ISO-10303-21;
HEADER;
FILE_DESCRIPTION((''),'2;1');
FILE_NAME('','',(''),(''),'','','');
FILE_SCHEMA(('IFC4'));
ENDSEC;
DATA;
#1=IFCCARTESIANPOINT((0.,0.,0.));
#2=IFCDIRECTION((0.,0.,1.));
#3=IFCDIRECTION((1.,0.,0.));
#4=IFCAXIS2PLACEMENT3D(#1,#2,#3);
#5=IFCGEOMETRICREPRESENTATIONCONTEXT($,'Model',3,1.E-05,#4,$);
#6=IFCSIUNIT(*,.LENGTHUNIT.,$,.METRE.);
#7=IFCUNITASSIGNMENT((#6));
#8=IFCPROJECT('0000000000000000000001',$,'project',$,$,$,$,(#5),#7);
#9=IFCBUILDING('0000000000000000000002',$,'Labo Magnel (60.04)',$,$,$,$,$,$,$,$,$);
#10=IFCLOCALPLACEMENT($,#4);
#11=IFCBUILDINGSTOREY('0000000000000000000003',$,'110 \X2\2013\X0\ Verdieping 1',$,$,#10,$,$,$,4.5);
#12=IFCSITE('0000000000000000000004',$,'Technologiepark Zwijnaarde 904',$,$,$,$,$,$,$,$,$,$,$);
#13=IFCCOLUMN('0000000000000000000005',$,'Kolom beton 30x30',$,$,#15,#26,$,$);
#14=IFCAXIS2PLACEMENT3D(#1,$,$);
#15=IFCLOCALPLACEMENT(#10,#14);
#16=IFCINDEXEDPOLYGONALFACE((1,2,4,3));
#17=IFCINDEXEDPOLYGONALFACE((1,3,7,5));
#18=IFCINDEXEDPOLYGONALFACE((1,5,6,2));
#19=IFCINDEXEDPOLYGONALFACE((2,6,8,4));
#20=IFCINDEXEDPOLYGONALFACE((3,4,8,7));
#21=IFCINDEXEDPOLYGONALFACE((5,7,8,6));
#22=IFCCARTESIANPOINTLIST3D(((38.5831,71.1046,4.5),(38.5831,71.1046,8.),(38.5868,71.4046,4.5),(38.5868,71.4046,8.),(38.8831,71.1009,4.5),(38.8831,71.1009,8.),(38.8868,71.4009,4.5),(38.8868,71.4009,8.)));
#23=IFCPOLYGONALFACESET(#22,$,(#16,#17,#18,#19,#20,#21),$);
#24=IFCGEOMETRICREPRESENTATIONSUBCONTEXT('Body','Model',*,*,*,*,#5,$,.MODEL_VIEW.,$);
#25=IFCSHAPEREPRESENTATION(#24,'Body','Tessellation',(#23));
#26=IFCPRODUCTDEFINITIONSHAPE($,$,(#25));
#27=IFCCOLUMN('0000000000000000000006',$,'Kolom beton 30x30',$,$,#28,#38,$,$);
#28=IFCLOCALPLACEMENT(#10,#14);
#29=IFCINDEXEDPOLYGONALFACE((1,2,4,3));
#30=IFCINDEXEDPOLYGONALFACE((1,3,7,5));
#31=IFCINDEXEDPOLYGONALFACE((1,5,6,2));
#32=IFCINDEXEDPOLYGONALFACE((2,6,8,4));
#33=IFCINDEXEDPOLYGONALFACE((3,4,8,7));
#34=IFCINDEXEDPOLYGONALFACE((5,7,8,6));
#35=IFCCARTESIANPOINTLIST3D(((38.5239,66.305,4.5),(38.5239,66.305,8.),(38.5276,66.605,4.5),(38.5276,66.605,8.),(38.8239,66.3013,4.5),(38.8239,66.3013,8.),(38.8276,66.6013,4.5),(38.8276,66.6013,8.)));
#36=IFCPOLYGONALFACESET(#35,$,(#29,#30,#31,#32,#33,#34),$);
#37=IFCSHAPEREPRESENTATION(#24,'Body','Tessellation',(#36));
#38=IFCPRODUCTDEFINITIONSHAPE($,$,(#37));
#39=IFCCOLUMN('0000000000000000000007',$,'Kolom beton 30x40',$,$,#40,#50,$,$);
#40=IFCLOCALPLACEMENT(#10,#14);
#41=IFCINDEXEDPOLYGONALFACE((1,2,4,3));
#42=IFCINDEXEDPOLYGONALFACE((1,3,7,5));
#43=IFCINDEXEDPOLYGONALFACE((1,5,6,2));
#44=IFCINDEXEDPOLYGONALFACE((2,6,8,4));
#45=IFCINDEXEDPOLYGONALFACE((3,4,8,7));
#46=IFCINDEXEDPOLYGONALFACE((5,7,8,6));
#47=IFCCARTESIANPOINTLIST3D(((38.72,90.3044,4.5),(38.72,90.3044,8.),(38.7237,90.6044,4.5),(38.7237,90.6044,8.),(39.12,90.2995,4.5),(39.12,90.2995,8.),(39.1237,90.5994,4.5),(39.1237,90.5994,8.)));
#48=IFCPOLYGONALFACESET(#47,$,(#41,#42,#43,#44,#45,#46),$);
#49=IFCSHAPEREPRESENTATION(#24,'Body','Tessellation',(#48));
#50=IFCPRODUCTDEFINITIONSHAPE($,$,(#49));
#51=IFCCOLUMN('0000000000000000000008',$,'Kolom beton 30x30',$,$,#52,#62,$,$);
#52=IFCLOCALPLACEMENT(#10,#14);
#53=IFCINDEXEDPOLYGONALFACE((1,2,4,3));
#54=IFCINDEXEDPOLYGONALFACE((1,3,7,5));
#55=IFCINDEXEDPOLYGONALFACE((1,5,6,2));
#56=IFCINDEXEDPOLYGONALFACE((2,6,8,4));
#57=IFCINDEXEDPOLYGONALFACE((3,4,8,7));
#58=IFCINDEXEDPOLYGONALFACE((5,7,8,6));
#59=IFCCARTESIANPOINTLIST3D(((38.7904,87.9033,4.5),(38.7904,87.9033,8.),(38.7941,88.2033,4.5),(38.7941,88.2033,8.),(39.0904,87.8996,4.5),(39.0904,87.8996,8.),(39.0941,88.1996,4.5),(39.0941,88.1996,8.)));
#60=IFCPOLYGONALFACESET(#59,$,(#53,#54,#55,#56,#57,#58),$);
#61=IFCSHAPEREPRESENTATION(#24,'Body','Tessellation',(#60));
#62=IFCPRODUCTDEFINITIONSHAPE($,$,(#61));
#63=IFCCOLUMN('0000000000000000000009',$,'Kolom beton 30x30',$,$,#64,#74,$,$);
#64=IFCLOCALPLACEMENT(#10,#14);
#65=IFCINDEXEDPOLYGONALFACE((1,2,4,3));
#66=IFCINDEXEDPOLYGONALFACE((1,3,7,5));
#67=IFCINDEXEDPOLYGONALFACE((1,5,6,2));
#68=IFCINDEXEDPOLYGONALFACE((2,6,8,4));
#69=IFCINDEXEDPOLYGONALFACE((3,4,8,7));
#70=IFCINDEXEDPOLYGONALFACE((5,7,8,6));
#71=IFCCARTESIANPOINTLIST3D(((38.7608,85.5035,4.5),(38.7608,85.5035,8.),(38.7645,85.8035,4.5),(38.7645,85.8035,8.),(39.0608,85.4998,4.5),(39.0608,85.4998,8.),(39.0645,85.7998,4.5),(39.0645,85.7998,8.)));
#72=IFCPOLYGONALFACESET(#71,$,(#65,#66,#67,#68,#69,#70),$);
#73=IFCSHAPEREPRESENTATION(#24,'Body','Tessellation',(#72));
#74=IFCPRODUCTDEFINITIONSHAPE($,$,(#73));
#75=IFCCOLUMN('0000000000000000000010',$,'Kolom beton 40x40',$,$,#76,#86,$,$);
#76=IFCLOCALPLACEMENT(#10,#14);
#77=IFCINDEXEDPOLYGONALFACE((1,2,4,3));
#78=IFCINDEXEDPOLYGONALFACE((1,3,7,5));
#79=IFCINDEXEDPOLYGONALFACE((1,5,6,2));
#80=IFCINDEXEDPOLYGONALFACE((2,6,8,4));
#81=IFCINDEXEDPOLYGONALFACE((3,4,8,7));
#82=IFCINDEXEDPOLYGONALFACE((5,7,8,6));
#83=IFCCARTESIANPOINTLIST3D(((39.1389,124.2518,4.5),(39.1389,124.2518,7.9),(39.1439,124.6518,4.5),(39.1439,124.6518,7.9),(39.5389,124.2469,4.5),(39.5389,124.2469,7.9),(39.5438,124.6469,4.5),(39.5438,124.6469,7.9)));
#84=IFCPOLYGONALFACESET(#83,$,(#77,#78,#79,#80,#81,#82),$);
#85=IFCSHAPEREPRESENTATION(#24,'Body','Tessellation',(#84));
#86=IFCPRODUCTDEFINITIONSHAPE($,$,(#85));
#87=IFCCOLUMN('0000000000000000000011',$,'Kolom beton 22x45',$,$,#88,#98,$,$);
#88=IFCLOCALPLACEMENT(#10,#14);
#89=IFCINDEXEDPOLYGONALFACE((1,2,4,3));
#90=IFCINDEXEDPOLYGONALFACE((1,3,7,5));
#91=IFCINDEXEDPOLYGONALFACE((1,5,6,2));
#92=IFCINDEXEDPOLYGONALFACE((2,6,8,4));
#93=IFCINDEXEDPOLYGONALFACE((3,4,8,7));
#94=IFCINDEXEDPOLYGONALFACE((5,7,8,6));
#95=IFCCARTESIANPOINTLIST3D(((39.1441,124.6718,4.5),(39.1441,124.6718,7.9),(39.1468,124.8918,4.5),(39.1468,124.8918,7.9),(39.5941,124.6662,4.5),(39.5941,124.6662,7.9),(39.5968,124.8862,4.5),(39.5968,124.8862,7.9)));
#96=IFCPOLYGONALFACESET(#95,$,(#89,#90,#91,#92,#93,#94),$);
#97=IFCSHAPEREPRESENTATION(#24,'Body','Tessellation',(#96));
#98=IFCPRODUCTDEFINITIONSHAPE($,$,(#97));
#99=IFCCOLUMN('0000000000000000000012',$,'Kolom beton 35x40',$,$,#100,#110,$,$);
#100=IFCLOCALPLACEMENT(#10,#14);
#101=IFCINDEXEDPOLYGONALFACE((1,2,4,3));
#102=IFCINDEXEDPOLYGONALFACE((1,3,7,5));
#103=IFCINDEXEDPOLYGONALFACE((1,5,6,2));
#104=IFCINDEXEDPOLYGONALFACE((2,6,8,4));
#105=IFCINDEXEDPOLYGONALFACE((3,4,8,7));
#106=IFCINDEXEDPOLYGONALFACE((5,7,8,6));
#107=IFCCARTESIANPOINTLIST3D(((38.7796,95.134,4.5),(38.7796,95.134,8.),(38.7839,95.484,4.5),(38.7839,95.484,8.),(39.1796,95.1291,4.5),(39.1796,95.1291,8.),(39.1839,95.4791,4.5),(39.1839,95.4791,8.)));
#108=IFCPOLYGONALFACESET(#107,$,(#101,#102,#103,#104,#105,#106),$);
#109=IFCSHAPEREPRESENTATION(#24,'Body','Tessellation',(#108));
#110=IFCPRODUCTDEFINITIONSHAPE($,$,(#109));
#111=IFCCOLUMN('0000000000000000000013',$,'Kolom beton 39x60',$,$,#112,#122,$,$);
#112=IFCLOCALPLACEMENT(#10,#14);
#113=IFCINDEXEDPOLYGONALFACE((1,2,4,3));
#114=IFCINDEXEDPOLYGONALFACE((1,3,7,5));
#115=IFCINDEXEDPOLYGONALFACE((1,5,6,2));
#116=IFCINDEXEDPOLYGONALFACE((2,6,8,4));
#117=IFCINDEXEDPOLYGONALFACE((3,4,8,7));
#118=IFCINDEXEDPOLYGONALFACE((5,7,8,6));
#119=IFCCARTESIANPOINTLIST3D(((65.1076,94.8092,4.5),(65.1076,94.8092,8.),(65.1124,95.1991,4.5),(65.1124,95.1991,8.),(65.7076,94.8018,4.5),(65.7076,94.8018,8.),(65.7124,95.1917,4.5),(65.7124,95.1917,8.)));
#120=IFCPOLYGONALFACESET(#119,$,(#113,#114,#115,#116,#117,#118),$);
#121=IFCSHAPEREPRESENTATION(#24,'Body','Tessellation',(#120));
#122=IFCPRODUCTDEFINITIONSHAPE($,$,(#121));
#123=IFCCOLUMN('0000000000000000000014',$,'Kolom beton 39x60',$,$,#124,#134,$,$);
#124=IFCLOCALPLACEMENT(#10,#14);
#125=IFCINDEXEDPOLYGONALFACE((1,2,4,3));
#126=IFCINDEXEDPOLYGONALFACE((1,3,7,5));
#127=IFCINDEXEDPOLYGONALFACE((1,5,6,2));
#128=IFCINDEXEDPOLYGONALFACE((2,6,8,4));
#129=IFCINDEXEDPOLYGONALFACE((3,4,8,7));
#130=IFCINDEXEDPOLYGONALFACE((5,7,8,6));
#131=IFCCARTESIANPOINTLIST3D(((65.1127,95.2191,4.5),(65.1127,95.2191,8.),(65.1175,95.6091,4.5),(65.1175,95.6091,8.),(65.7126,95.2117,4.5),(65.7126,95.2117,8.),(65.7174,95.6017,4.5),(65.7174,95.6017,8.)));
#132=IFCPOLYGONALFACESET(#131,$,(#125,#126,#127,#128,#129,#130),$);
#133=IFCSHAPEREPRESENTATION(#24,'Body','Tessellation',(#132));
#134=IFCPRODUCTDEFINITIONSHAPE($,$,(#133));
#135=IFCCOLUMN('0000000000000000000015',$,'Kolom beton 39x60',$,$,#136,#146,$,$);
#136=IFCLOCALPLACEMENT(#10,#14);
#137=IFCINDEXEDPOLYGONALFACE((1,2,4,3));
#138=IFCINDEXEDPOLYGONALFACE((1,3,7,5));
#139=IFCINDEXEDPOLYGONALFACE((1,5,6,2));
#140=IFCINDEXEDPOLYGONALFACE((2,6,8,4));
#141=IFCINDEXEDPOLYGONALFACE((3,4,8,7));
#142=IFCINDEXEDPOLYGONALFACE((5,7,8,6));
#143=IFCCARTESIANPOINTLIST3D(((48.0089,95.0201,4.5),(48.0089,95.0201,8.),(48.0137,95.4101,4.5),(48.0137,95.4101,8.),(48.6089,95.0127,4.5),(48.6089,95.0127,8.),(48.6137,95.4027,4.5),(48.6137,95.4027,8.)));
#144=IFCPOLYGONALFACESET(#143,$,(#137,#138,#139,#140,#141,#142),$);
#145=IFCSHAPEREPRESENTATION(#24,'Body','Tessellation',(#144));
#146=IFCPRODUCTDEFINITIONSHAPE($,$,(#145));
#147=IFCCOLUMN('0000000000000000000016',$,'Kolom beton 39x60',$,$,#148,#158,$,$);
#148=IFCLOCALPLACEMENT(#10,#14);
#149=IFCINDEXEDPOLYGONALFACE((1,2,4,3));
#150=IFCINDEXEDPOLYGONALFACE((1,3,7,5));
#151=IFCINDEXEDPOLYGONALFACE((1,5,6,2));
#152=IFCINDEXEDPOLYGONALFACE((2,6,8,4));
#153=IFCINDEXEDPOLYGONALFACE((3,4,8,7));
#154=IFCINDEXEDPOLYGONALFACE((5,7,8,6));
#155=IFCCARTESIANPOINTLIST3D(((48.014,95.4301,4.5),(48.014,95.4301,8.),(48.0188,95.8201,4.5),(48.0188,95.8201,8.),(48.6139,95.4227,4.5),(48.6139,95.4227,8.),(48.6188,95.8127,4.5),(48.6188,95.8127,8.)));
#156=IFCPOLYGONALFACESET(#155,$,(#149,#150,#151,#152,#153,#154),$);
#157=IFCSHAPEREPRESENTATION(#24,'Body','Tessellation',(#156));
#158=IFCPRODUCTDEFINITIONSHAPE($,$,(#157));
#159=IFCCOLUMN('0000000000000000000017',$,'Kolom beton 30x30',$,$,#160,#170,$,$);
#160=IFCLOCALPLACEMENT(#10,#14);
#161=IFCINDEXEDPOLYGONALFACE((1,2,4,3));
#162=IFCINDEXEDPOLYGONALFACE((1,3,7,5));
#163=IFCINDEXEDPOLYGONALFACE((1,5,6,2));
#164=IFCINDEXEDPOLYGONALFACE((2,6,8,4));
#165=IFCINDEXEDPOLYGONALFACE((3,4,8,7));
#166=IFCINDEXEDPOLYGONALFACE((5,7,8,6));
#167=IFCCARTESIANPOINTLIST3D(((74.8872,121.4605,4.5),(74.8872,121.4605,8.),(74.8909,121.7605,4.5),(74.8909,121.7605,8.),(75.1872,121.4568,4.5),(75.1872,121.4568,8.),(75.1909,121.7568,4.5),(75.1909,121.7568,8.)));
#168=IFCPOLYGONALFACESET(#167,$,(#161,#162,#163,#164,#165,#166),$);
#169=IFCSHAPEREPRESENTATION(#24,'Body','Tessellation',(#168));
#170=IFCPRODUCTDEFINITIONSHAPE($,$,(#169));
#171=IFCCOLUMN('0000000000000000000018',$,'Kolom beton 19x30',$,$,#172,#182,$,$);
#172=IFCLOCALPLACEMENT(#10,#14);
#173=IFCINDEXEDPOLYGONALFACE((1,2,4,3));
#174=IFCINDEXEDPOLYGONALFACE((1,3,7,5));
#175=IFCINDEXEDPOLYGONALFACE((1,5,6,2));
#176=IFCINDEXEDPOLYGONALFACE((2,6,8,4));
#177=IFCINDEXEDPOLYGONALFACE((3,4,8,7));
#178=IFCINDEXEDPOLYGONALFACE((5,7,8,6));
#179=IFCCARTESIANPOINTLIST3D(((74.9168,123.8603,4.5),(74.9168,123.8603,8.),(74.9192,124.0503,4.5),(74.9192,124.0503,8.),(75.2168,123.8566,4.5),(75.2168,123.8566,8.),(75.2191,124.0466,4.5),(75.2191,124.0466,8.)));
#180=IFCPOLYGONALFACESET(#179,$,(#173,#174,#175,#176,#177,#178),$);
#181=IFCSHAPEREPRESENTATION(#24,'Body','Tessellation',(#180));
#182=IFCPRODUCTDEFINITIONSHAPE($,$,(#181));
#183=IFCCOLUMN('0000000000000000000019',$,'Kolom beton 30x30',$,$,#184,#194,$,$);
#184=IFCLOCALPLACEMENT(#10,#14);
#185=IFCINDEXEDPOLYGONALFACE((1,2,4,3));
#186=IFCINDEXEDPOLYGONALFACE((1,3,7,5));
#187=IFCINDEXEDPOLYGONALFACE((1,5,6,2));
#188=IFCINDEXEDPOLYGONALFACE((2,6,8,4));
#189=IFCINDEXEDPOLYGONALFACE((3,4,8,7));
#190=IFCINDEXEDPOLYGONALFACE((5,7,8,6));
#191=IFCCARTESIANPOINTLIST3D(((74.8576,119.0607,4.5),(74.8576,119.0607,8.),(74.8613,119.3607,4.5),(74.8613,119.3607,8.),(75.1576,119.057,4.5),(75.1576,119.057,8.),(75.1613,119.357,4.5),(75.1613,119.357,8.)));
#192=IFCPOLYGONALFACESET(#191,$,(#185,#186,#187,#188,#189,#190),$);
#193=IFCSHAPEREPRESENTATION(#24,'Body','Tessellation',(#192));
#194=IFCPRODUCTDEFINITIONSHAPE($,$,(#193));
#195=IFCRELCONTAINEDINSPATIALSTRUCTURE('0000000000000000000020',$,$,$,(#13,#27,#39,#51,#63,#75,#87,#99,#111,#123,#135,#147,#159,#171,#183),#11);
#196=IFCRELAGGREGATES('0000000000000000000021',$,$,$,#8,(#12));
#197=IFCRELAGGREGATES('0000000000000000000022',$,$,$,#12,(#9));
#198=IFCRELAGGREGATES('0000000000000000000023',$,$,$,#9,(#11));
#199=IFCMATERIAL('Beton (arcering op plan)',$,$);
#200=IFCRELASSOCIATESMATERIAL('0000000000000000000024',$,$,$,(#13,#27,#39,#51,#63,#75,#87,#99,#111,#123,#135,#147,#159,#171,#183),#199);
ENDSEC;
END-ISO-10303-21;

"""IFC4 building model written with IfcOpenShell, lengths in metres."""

from ifc_helpers import new_model, si_unit, frame, origin, origin_with_axes, place, context, subcontext, project, spatial, polyline, outline, extrude, material, element, save


model = new_model("IFC4")

# Units and contexts
model_context = context("Model", 3, precision=1e-05, world=origin_with_axes())
body_context = subcontext(model_context, "Body", "Model", "MODEL_VIEW")
ifc_project = project(units=[si_unit("LENGTHUNIT", "METRE")], contexts=[model_context])

# Site, building, storey
site = spatial("IfcSite", under=ifc_project, Name="Technologiepark Zwijnaarde 904")
building = spatial("IfcBuilding", under=site, Name="Labo Magnel (60.04)")
storey_placement = place(None, origin_with_axes())
storey = spatial("IfcBuildingStorey", under=building, at=storey_placement, Name="110 – Verdieping 1", Elevation=4.5)

# Columns
ifc_material = material(Name="Beton (arcering op plan)")
column_1_placement = place(storey_placement, frame((0.0, 0.0, 4.5), z_axis=(0.0, 0.0, 1.0), x_axis=(1.0, 0.0, 0.0)))
element("IfcColumn", 1, at=column_1_placement, inside=storey, material=ifc_material, Name="Kolom beton 30x30", context=body_context, shape_type="SweptSolid", body=[
    extrude(outline(polyline([(38.8868, 71.4009), (38.5868, 71.4046), (38.5831, 71.1046), (38.8831, 71.1009), (38.8868, 71.4009)])), origin(), (0.0, 0.0, 1.0), 3.5),
])
column_2_placement = place(storey_placement, frame((0.0, 0.0, 4.5), z_axis=(0.0, 0.0, 1.0), x_axis=(1.0, 0.0, 0.0)))
element("IfcColumn", 2, at=column_2_placement, inside=storey, material=ifc_material, Name="Kolom beton 30x30", context=body_context, shape_type="SweptSolid", body=[
    extrude(outline(polyline([(38.8276, 66.6013), (38.5276, 66.605), (38.5239, 66.305), (38.8239, 66.3013), (38.8276, 66.6013)])), origin(), (0.0, 0.0, 1.0), 3.5),
])
column_3_placement = place(storey_placement, frame((0.0, 0.0, 4.5), z_axis=(0.0, 0.0, 1.0), x_axis=(1.0, 0.0, 0.0)))
element("IfcColumn", 3, at=column_3_placement, inside=storey, material=ifc_material, Name="Kolom beton 30x40", context=body_context, shape_type="SweptSolid", body=[
    extrude(outline(polyline([(39.1237, 90.5994), (38.7237, 90.6044), (38.72, 90.3044), (39.12, 90.2995), (39.1237, 90.5994)])), origin(), (0.0, 0.0, 1.0), 3.5),
])
column_4_placement = place(storey_placement, frame((0.0, 0.0, 4.5), z_axis=(0.0, 0.0, 1.0), x_axis=(1.0, 0.0, 0.0)))
element("IfcColumn", 4, at=column_4_placement, inside=storey, material=ifc_material, Name="Kolom beton 30x30", context=body_context, shape_type="SweptSolid", body=[
    extrude(outline(polyline([(39.0941, 88.1996), (38.7941, 88.2033), (38.7904, 87.9033), (39.0904, 87.8996), (39.0941, 88.1996)])), origin(), (0.0, 0.0, 1.0), 3.5),
])
column_5_placement = place(storey_placement, frame((0.0, 0.0, 4.5), z_axis=(0.0, 0.0, 1.0), x_axis=(1.0, 0.0, 0.0)))
element("IfcColumn", 5, at=column_5_placement, inside=storey, material=ifc_material, Name="Kolom beton 30x30", context=body_context, shape_type="SweptSolid", body=[
    extrude(outline(polyline([(39.0645, 85.7998), (38.7645, 85.8035), (38.7608, 85.5035), (39.0608, 85.4998), (39.0645, 85.7998)])), origin(), (0.0, 0.0, 1.0), 3.5),
])
column_6_placement = place(storey_placement, frame((0.0, 0.0, 4.5), z_axis=(0.0, 0.0, 1.0), x_axis=(1.0, 0.0, 0.0)))
element("IfcColumn", 6, at=column_6_placement, inside=storey, material=ifc_material, Name="Kolom beton 40x40", context=body_context, shape_type="SweptSolid", body=[
    extrude(outline(polyline([(39.5438, 124.6469), (39.1439, 124.6518), (39.1389, 124.2518), (39.5389, 124.2469), (39.5438, 124.6469)])), origin(), (0.0, 0.0, 1.0), 3.4),
])
column_7_placement = place(storey_placement, frame((0.0, 0.0, 4.5), z_axis=(0.0, 0.0, 1.0), x_axis=(1.0, 0.0, 0.0)))
element("IfcColumn", 7, at=column_7_placement, inside=storey, material=ifc_material, Name="Kolom beton 22x45", context=body_context, shape_type="SweptSolid", body=[
    extrude(outline(polyline([(39.5968, 124.8862), (39.1468, 124.8918), (39.1441, 124.6718), (39.5941, 124.6662), (39.5968, 124.8862)])), origin(), (0.0, 0.0, 1.0), 3.4),
])
column_8_placement = place(storey_placement, frame((0.0, 0.0, 4.5), z_axis=(0.0, 0.0, 1.0), x_axis=(1.0, 0.0, 0.0)))
element("IfcColumn", 8, at=column_8_placement, inside=storey, material=ifc_material, Name="Kolom beton 35x40", context=body_context, shape_type="SweptSolid", body=[
    extrude(outline(polyline([(39.1839, 95.4791), (38.7839, 95.484), (38.7796, 95.134), (39.1796, 95.1291), (39.1839, 95.4791)])), origin(), (0.0, 0.0, 1.0), 3.5),
])
column_9_placement = place(storey_placement, frame((0.0, 0.0, 4.5), z_axis=(0.0, 0.0, 1.0), x_axis=(1.0, 0.0, 0.0)))
element("IfcColumn", 9, at=column_9_placement, inside=storey, material=ifc_material, Name="Kolom beton 39x60", context=body_context, shape_type="SweptSolid", body=[
    extrude(outline(polyline([(65.7124, 95.1917), (65.1124, 95.1991), (65.1076, 94.8092), (65.7076, 94.8018), (65.7124, 95.1917)])), origin(), (0.0, 0.0, 1.0), 3.5),
])
column_10_placement = place(storey_placement, frame((0.0, 0.0, 4.5), z_axis=(0.0, 0.0, 1.0), x_axis=(1.0, 0.0, 0.0)))
element("IfcColumn", 10, at=column_10_placement, inside=storey, material=ifc_material, Name="Kolom beton 39x60", context=body_context, shape_type="SweptSolid", body=[
    extrude(outline(polyline([(65.7174, 95.6017), (65.1175, 95.6091), (65.1127, 95.2191), (65.7126, 95.2117), (65.7174, 95.6017)])), origin(), (0.0, 0.0, 1.0), 3.5),
])
column_11_placement = place(storey_placement, frame((0.0, 0.0, 4.5), z_axis=(0.0, 0.0, 1.0), x_axis=(1.0, 0.0, 0.0)))
element("IfcColumn", 11, at=column_11_placement, inside=storey, material=ifc_material, Name="Kolom beton 39x60", context=body_context, shape_type="SweptSolid", body=[
    extrude(outline(polyline([(48.6137, 95.4027), (48.0137, 95.4101), (48.0089, 95.0201), (48.6089, 95.0127), (48.6137, 95.4027)])), origin(), (0.0, 0.0, 1.0), 3.5),
])
column_12_placement = place(storey_placement, frame((0.0, 0.0, 4.5), z_axis=(0.0, 0.0, 1.0), x_axis=(1.0, 0.0, 0.0)))
element("IfcColumn", 12, at=column_12_placement, inside=storey, material=ifc_material, Name="Kolom beton 39x60", context=body_context, shape_type="SweptSolid", body=[
    extrude(outline(polyline([(48.6188, 95.8127), (48.0188, 95.8201), (48.014, 95.4301), (48.6139, 95.4227), (48.6188, 95.8127)])), origin(), (0.0, 0.0, 1.0), 3.5),
])
column_13_placement = place(storey_placement, frame((0.0, 0.0, 4.5), z_axis=(0.0, 0.0, 1.0), x_axis=(1.0, 0.0, 0.0)))
element("IfcColumn", 13, at=column_13_placement, inside=storey, material=ifc_material, Name="Kolom beton 30x30", context=body_context, shape_type="SweptSolid", body=[
    extrude(outline(polyline([(75.1909, 121.7568), (74.8909, 121.7605), (74.8872, 121.4605), (75.1872, 121.4568), (75.1909, 121.7568)])), origin(), (0.0, 0.0, 1.0), 3.5),
])
column_14_placement = place(storey_placement, frame((0.0, 0.0, 4.5), z_axis=(0.0, 0.0, 1.0), x_axis=(1.0, 0.0, 0.0)))
element("IfcColumn", 14, at=column_14_placement, inside=storey, material=ifc_material, Name="Kolom beton 19x30", context=body_context, shape_type="SweptSolid", body=[
    extrude(outline(polyline([(75.2191, 124.0466), (74.9192, 124.0503), (74.9168, 123.8603), (75.2168, 123.8566), (75.2191, 124.0466)])), origin(), (0.0, 0.0, 1.0), 3.5),
])
column_15_placement = place(storey_placement, frame((0.0, 0.0, 4.5), z_axis=(0.0, 0.0, 1.0), x_axis=(1.0, 0.0, 0.0)))
element("IfcColumn", 15, at=column_15_placement, inside=storey, material=ifc_material, Name="Kolom beton 30x30", context=body_context, shape_type="SweptSolid", body=[
    extrude(outline(polyline([(75.1613, 119.357), (74.8613, 119.3607), (74.8576, 119.0607), (75.1576, 119.057), (75.1613, 119.357)])), origin(), (0.0, 0.0, 1.0), 3.5),
])

save(model, "model.ifc")
